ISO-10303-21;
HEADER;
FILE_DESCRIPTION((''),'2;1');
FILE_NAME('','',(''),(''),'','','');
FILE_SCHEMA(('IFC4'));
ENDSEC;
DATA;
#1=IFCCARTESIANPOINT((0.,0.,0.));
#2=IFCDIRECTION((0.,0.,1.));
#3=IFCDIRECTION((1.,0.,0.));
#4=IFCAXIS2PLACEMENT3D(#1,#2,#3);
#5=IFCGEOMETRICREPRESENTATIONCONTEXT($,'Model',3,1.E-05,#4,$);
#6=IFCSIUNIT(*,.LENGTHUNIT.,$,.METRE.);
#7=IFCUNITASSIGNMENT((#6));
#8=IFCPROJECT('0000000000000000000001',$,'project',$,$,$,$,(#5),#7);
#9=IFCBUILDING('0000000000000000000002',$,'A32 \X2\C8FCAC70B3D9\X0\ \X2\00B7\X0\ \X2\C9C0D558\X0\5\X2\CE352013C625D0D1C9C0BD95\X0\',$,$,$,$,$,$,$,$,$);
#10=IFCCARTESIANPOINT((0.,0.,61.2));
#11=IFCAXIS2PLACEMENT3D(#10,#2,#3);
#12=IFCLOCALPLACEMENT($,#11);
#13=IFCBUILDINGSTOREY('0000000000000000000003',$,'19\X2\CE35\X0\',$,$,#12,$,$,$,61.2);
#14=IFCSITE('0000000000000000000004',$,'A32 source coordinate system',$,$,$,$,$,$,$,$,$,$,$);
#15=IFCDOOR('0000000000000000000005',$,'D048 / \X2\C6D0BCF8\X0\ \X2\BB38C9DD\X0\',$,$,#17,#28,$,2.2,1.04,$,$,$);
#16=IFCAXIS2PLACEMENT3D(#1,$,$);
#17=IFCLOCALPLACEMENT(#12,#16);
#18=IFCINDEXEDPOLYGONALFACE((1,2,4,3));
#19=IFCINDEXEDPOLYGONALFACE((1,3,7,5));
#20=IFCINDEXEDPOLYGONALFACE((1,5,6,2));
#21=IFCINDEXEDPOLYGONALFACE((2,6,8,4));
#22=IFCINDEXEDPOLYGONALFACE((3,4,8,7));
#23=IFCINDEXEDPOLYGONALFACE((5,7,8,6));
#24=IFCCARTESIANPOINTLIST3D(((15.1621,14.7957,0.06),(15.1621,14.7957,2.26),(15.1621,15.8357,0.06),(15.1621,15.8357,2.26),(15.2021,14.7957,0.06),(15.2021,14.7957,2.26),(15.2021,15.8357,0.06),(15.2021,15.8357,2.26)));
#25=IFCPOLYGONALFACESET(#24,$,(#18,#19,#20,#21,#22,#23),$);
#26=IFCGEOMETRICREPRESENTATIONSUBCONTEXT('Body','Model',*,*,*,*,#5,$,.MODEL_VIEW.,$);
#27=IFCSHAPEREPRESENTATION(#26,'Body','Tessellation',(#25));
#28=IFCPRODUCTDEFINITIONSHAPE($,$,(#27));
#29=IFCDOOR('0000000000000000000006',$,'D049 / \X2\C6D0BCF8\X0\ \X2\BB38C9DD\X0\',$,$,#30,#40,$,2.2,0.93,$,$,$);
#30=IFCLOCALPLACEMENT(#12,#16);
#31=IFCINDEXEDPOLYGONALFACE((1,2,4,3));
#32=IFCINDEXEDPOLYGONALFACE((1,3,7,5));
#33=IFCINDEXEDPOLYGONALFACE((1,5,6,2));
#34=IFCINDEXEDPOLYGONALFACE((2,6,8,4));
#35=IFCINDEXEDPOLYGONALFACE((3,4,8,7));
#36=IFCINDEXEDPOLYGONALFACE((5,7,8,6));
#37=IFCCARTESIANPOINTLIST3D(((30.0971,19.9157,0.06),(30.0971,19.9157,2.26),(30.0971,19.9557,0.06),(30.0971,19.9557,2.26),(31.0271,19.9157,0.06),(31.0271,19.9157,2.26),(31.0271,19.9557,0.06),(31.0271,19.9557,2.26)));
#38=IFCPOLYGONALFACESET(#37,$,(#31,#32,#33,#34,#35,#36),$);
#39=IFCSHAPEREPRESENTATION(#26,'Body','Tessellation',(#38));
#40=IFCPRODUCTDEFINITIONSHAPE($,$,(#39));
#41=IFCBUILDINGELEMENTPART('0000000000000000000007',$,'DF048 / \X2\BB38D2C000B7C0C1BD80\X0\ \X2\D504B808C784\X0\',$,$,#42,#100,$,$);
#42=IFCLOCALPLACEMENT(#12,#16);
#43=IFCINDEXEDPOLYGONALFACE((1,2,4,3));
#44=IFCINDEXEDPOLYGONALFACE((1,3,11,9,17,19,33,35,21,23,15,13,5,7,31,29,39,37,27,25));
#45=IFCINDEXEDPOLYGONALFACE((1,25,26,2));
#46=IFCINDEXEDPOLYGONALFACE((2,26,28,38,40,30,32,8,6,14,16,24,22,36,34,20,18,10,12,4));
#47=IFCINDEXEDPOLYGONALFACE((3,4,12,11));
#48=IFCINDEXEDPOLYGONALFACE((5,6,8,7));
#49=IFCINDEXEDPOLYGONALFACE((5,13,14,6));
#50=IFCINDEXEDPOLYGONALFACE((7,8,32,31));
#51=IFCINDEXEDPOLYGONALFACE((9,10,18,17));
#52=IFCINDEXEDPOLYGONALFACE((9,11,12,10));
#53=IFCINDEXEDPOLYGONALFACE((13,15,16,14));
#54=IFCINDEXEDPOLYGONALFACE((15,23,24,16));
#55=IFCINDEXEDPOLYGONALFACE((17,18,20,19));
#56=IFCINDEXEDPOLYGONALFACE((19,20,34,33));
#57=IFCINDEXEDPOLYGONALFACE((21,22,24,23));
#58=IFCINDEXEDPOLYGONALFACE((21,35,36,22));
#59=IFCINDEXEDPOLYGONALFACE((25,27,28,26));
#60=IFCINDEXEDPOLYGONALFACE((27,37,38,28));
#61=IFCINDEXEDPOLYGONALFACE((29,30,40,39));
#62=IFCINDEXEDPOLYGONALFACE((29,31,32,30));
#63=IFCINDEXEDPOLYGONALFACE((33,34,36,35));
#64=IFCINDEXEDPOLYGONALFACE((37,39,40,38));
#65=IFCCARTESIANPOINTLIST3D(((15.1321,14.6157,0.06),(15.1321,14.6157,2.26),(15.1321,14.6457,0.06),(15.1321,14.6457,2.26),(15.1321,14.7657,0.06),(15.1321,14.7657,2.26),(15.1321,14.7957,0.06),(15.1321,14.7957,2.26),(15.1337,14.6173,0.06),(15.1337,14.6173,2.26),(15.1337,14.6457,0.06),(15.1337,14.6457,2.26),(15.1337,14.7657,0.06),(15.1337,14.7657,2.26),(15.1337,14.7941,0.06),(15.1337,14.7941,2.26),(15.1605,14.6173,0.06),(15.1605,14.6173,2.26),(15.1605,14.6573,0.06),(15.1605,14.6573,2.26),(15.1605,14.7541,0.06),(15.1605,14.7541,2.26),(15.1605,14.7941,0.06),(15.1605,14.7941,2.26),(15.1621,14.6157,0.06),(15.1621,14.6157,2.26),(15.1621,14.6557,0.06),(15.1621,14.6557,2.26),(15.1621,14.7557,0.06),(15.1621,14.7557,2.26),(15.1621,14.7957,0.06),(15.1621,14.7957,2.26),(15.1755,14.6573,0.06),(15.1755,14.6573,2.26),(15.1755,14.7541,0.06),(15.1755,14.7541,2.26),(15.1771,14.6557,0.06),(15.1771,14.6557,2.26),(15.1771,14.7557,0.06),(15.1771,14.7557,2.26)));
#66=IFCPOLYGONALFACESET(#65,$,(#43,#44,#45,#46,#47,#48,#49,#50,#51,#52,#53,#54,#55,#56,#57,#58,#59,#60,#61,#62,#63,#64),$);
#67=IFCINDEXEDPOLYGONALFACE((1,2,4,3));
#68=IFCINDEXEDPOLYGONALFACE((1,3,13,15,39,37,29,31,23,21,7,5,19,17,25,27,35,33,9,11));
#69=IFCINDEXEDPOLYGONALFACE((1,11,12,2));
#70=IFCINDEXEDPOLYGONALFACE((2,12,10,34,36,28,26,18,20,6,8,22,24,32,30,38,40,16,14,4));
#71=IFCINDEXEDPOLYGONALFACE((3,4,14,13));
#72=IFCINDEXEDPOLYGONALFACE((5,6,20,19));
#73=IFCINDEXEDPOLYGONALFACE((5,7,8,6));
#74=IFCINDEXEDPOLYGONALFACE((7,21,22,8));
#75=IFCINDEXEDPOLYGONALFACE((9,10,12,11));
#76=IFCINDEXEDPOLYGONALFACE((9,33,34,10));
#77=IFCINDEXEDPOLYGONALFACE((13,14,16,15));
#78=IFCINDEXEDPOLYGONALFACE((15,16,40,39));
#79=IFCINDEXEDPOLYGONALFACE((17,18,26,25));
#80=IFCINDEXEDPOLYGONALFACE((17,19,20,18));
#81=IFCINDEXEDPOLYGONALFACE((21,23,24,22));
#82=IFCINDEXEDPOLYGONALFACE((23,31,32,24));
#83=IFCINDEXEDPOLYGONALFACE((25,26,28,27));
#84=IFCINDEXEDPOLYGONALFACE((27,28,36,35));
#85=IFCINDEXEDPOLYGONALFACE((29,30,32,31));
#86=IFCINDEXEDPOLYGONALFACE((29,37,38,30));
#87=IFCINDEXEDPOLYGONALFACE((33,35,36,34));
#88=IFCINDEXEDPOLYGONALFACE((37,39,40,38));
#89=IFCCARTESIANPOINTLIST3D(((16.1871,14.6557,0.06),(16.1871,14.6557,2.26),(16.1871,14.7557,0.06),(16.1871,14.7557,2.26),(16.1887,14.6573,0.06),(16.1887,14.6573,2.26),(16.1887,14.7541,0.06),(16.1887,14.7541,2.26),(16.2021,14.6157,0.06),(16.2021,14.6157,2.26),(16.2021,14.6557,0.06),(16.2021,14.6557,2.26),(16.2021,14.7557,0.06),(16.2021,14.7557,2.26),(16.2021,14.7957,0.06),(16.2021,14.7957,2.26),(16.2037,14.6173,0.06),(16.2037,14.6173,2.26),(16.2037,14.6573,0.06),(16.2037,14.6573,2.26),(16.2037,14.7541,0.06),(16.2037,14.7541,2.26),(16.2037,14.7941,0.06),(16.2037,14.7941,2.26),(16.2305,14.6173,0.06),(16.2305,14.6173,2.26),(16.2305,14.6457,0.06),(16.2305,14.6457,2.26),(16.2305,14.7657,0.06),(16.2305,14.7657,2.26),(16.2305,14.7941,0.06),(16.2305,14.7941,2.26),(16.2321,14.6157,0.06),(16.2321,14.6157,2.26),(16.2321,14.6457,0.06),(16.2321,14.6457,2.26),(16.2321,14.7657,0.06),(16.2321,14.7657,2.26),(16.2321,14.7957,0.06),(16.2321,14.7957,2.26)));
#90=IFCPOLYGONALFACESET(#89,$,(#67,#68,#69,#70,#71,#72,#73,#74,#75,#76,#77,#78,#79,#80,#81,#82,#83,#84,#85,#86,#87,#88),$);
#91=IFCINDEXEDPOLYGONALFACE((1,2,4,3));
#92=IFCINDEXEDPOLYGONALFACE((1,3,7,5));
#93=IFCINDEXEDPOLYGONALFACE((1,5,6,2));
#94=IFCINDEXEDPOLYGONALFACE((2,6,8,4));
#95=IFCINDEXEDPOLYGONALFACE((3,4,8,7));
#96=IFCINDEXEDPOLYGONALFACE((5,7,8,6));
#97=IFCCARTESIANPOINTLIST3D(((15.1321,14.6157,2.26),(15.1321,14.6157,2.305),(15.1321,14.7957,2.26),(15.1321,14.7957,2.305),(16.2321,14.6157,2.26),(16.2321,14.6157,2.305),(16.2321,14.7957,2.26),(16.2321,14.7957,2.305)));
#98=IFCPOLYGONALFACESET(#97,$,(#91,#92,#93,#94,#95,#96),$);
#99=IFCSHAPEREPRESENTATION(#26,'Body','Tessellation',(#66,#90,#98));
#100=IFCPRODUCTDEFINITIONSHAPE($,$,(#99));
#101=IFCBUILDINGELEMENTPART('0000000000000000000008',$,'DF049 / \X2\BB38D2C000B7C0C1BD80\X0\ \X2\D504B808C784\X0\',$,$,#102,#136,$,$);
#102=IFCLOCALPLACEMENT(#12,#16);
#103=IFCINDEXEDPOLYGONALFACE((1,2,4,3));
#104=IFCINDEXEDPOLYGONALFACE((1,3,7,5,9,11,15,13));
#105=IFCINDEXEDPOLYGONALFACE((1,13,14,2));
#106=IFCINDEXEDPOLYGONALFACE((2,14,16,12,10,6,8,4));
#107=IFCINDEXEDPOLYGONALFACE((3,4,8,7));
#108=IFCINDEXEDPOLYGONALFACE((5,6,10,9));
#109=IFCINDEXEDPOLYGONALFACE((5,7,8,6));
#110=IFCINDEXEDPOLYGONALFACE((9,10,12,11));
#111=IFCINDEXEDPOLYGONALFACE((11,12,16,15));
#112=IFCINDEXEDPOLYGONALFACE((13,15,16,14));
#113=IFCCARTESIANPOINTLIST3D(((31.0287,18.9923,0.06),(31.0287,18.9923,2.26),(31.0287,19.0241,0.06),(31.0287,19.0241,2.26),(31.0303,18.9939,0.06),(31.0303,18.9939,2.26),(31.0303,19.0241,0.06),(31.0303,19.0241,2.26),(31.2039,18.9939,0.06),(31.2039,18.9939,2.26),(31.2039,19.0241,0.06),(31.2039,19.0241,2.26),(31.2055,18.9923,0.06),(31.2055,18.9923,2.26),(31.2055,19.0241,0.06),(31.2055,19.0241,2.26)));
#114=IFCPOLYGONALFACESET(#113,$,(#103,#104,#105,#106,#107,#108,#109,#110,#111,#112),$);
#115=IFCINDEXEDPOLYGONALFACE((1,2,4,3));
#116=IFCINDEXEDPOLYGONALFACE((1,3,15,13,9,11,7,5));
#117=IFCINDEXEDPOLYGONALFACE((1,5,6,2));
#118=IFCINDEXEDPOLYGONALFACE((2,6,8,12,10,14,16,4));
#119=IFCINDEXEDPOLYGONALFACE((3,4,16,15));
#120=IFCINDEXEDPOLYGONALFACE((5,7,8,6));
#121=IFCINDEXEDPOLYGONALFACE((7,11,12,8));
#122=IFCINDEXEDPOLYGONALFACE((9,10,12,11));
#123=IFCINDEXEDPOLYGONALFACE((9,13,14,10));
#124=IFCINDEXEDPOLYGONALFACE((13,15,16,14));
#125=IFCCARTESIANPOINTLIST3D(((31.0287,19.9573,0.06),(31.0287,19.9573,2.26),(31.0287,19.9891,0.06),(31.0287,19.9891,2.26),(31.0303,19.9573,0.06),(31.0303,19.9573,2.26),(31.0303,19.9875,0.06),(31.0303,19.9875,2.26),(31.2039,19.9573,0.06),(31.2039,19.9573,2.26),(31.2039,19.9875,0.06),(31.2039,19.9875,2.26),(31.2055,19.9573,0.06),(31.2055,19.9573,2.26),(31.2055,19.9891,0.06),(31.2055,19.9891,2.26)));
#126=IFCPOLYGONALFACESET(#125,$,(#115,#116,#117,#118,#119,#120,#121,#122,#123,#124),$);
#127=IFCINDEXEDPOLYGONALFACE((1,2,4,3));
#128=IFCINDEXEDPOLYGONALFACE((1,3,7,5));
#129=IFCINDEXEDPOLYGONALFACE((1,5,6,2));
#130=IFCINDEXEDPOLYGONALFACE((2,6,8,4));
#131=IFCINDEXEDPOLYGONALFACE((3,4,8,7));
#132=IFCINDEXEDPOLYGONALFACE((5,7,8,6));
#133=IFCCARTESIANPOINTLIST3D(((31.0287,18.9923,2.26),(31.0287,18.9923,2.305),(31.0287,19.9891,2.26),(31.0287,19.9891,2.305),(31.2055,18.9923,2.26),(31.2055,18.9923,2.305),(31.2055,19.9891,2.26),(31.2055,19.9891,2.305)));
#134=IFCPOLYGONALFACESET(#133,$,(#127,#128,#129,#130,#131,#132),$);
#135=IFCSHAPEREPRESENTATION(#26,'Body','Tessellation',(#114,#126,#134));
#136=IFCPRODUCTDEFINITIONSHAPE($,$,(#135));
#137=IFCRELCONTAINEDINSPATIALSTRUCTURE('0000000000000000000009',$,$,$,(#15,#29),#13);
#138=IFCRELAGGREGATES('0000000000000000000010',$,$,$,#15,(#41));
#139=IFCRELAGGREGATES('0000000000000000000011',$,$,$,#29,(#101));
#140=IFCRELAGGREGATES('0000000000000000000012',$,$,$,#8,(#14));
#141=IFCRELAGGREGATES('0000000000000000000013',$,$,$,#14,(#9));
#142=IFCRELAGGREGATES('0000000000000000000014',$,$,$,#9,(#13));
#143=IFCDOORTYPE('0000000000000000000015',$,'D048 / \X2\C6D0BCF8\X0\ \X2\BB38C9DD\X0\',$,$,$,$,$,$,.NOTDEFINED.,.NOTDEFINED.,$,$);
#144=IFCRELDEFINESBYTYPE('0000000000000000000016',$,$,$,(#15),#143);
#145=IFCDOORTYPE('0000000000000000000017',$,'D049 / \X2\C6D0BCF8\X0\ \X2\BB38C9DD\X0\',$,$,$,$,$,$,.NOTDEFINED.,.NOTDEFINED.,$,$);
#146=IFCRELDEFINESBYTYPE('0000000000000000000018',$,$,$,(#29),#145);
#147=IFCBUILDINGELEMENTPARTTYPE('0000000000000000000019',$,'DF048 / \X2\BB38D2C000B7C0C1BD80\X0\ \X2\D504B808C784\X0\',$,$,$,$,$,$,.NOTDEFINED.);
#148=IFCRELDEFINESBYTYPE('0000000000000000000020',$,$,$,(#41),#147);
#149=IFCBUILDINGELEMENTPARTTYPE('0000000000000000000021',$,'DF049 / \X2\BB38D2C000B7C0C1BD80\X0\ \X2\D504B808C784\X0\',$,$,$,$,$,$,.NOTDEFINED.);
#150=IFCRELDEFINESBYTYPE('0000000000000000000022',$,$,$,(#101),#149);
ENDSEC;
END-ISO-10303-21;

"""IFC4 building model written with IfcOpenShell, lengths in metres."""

from ifc_helpers import new_model, si_unit, frame, origin, origin_with_axes, place, context, subcontext, project, spatial, polyline, outline, extrude, source, transform, mapped, type_object, type_shapes, element, aggregate, save


model = new_model("IFC4")

# Units and contexts
model_context = context("Model", 3, precision=1e-05, world=origin_with_axes())
body_context = subcontext(model_context, "Body", "Model", "MODEL_VIEW")
ifc_project = project(units=[si_unit("LENGTHUNIT", "METRE")], contexts=[model_context])

# Site, building, storey
storey_placement = place(None, frame((0.0, 0.0, 61.2), z_axis=(0.0, 0.0, 1.0), x_axis=(1.0, 0.0, 0.0)))
site = spatial("IfcSite", under=ifc_project, Name="A32 source coordinate system")
building = spatial("IfcBuilding", under=site, Name="A32 주거동 · 지하5층–옥탑지붕")
storey = spatial("IfcBuildingStorey", under=building, at=storey_placement, Name="19층", Elevation=61.2)

# Doors
door_type_1 = type_object("IfcDoorType", Name="D048 / 원본 문짝", OperationType="NOTDEFINED", PredefinedType="NOTDEFINED")
shared_shape_1 = source(origin(), body_context, "Body", "SweptSolid", [
    extrude(outline(polyline([(15.2021, 15.8357), (15.2021, 14.7957), (15.1621, 14.7957), (15.1621, 15.8357), (15.2021, 15.8357)])), frame((0.0, 0.0, 0.06)), (0.0, 0.0, 1.0), 2.2),
])
type_shapes(door_type_1, [shared_shape_1])
door_1_placement = place(storey_placement, origin_with_axes())
door_1 = element("IfcDoor", 1, at=door_1_placement, inside=storey, type_object=door_type_1, Name="D048 / 원본 문짝", OverallHeight=2.2, OverallWidth=1.04, context=body_context, shape_type="MappedRepresentation", body=[
    mapped(shared_shape_1, transform((0.0, 0.0, 0.0), scale=1.0)),
])
door_type_2 = type_object("IfcDoorType", Name="D049 / 원본 문짝", OperationType="NOTDEFINED", PredefinedType="NOTDEFINED")
shared_shape_2 = source(origin(), body_context, "Body", "SweptSolid", [
    extrude(outline(polyline([(31.0271, 19.9557), (31.0271, 19.9157), (30.0971, 19.9157), (30.0971, 19.9557), (31.0271, 19.9557)])), frame((0.0, 0.0, 0.06)), (0.0, 0.0, 1.0), 2.2),
])
type_shapes(door_type_2, [shared_shape_2])
door_2_placement = place(storey_placement, origin_with_axes())
door_2 = element("IfcDoor", 2, at=door_2_placement, inside=storey, type_object=door_type_2, Name="D049 / 원본 문짝", OverallHeight=2.2, OverallWidth=0.93, context=body_context, shape_type="MappedRepresentation", body=[
    mapped(shared_shape_2, transform((0.0, 0.0, 0.0), scale=1.0)),
])

# Building element parts
building_element_part_type_1 = type_object("IfcBuildingElementPartType", Name="DF048 / 문틀·상부 프레임", PredefinedType="NOTDEFINED")
shared_shape_3 = source(origin(), body_context, "Body", "SweptSolid", [
    extrude(outline(polyline([(15.1321, 14.7657), (15.1321, 14.7957), (15.1621, 14.7957), (15.1621, 14.7557), (15.1771, 14.7557), (15.1771, 14.6557), (15.1621, 14.6557), (15.1621, 14.6157), (15.1321, 14.6157), (15.1321, 14.6457), (15.1337, 14.6457), (15.1337, 14.6173), (15.1605, 14.6173), (15.1605, 14.6573), (15.1755, 14.6573), (15.1755, 14.7541), (15.1605, 14.7541), (15.1605, 14.7941), (15.1337, 14.7941), (15.1337, 14.7657), (15.1321, 14.7657)])), frame((0.0, 0.0, 0.06)), (0.0, 0.0, 1.0), 2.2),
    extrude(outline(polyline([(16.2305, 14.7941), (16.2037, 14.7941), (16.2037, 14.7541), (16.1887, 14.7541), (16.1887, 14.6573), (16.2037, 14.6573), (16.2037, 14.6173), (16.2305, 14.6173), (16.2305, 14.6457), (16.2321, 14.6457), (16.2321, 14.6157), (16.2021, 14.6157), (16.2021, 14.6557), (16.1871, 14.6557), (16.1871, 14.7557), (16.2021, 14.7557), (16.2021, 14.7957), (16.2321, 14.7957), (16.2321, 14.7657), (16.2305, 14.7657), (16.2305, 14.7941)])), frame((0.0, 0.0, 0.06)), (0.0, 0.0, 1.0), 2.2),
    extrude(outline(polyline([(15.1321, 14.6157), (15.1321, 14.7957), (16.2321, 14.7957), (16.2321, 14.6157), (15.1321, 14.6157)])), frame((0.0, 0.0, 2.26)), (0.0, 0.0, 1.0), 0.045),
])
type_shapes(building_element_part_type_1, [shared_shape_3])
building_element_part_1_placement = place(door_1_placement, origin_with_axes())
building_element_part_1 = element("IfcBuildingElementPart", 3, at=building_element_part_1_placement, type_object=building_element_part_type_1, Name="DF048 / 문틀·상부 프레임", context=body_context, shape_type="MappedRepresentation", body=[
    mapped(shared_shape_3, transform((0.0, 0.0, 0.0), scale=1.0)),
])
aggregate(door_1, [building_element_part_1])
building_element_part_type_2 = type_object("IfcBuildingElementPartType", Name="DF049 / 문틀·상부 프레임", PredefinedType="NOTDEFINED")
shared_shape_4 = source(origin(), body_context, "Body", "SweptSolid", [
    extrude(outline(polyline([(31.0303, 19.0241), (31.0303, 18.9939), (31.2039, 18.9939), (31.2039, 19.0241), (31.2055, 19.0241), (31.2055, 18.9923), (31.0287, 18.9923), (31.0287, 19.0241), (31.0303, 19.0241)])), frame((0.0, 0.0, 0.06)), (0.0, 0.0, 1.0), 2.2),
    extrude(outline(polyline([(31.0287, 19.9891), (31.2055, 19.9891), (31.2055, 19.9573), (31.2039, 19.9573), (31.2039, 19.9875), (31.0303, 19.9875), (31.0303, 19.9573), (31.0287, 19.9573), (31.0287, 19.9891)])), frame((0.0, 0.0, 0.06)), (0.0, 0.0, 1.0), 2.2),
    extrude(outline(polyline([(31.0287, 18.9923), (31.0287, 19.9891), (31.2055, 19.9891), (31.2055, 18.9923), (31.0287, 18.9923)])), frame((0.0, 0.0, 2.26)), (0.0, 0.0, 1.0), 0.045),
])
type_shapes(building_element_part_type_2, [shared_shape_4])
building_element_part_2_placement = place(door_2_placement, origin_with_axes())
building_element_part_2 = element("IfcBuildingElementPart", 4, at=building_element_part_2_placement, type_object=building_element_part_type_2, Name="DF049 / 문틀·상부 프레임", context=body_context, shape_type="MappedRepresentation", body=[
    mapped(shared_shape_4, transform((0.0, 0.0, 0.0), scale=1.0)),
])
aggregate(door_2, [building_element_part_2])

save(model, "model.ifc")
